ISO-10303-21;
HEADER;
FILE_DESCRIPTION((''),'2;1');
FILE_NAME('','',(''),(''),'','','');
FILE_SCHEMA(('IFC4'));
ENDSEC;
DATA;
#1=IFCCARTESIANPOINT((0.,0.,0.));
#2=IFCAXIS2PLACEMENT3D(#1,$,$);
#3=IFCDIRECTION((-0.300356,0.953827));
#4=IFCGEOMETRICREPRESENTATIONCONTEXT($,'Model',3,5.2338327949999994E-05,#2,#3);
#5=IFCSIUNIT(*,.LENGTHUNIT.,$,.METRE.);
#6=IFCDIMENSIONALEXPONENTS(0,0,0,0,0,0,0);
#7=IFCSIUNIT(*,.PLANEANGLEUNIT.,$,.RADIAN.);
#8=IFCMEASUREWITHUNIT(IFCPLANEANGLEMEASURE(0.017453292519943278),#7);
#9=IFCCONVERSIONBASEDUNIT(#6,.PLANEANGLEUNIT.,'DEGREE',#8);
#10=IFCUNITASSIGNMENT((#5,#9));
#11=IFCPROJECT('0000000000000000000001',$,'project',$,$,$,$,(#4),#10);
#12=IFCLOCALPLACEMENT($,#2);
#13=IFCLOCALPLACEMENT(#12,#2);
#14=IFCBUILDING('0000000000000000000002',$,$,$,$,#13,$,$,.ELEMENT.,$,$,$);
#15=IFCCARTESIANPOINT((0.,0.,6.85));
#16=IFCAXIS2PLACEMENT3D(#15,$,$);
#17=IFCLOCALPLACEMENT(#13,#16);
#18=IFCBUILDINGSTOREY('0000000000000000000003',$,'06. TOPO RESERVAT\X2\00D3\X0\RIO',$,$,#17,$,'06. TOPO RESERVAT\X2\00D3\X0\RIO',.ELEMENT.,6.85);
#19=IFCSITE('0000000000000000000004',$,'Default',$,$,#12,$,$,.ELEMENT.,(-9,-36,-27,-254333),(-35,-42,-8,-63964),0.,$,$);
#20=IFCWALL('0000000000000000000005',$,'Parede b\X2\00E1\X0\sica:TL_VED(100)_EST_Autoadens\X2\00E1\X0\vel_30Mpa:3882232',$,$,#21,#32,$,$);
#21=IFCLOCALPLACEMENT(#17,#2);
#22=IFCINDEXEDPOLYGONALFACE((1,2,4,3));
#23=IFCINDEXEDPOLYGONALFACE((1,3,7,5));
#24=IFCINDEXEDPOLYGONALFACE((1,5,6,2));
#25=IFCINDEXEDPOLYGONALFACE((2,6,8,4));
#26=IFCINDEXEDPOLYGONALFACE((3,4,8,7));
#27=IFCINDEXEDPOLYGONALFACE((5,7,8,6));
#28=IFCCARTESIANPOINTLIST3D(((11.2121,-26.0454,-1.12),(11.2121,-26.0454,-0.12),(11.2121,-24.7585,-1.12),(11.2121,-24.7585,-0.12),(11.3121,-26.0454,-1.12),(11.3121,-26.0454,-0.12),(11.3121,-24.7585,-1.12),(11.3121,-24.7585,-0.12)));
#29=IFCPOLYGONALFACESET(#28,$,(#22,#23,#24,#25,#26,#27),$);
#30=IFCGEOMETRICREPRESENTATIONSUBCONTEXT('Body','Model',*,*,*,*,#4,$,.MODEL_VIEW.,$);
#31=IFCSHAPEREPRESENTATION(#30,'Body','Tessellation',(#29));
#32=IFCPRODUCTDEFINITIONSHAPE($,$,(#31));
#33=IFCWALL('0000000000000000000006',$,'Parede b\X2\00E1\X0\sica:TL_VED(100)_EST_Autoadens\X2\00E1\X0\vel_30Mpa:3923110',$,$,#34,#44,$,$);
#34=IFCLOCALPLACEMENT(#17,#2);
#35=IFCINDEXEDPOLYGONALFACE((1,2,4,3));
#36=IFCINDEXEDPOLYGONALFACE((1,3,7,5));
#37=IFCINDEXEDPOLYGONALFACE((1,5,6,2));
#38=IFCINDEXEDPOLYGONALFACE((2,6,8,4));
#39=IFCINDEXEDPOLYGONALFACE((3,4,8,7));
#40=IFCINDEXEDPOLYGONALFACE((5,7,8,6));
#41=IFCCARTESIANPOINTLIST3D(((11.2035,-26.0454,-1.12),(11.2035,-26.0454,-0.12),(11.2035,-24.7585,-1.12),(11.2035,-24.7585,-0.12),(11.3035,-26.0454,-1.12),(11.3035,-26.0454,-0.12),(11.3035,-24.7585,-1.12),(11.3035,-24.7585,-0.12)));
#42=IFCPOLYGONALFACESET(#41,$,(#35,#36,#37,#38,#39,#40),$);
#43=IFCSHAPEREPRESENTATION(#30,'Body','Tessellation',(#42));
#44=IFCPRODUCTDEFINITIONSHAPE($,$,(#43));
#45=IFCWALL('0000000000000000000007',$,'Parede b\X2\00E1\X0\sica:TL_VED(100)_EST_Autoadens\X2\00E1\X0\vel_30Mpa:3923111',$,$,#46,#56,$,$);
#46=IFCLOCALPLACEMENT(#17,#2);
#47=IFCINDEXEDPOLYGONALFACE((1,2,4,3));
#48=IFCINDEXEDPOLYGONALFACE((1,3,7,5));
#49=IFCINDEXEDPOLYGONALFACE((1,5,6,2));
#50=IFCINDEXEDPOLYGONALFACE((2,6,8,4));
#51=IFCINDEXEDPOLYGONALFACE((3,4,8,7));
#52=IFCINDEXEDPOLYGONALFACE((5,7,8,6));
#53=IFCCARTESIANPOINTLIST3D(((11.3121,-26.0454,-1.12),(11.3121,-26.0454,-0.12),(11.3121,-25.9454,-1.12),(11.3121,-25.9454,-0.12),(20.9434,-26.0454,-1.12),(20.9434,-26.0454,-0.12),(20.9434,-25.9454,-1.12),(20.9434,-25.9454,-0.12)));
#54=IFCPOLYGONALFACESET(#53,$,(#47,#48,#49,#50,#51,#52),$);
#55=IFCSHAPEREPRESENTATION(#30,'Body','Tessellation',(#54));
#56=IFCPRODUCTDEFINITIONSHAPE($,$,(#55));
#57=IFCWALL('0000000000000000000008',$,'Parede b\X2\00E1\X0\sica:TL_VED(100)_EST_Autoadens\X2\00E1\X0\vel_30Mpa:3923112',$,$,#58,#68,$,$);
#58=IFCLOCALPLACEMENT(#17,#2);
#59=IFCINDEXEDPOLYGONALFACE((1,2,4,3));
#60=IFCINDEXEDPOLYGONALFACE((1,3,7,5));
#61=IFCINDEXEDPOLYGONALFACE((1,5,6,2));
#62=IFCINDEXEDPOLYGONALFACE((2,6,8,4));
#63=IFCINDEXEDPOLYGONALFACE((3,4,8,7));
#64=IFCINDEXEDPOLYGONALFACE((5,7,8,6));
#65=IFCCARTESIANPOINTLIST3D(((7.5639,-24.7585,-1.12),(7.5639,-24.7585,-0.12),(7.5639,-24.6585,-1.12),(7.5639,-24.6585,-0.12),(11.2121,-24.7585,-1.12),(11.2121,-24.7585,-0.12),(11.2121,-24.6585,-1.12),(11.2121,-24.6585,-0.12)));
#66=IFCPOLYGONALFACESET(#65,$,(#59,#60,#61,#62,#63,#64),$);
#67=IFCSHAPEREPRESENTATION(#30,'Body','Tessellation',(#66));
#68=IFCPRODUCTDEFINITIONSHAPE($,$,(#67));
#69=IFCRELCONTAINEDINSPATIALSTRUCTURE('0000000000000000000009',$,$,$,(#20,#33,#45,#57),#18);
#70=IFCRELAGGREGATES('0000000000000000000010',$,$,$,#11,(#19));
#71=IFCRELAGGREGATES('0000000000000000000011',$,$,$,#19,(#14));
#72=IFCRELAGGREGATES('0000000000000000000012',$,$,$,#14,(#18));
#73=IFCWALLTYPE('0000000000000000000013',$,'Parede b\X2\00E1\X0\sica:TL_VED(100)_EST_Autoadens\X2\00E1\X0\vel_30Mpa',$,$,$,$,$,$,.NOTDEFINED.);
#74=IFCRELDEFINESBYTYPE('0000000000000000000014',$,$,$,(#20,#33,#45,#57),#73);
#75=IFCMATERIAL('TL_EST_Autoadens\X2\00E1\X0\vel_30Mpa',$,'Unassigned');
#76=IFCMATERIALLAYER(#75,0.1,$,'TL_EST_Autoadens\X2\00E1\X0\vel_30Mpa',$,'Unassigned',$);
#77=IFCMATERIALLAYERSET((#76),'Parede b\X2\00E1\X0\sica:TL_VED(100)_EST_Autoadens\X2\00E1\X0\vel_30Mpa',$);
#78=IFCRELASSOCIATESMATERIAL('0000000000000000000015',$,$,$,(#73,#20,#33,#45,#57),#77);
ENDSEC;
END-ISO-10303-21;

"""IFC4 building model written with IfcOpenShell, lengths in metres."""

from ifc_helpers import new_model, entity, si_unit, converted_unit, direction, frame, frame_2d, origin, place, context, subcontext, project, spatial, rectangle, extrude, material, layer, layer_set, layer_usage, type_object, element, save


model = new_model("IFC4")

# Units and contexts
model_context = context("Model", 3, precision=5.2338327949999994e-05, world=origin(), true_north=direction((-0.300356, 0.953827)))
body_context = subcontext(model_context, "Body", "Model", "MODEL_VIEW")
ifc_project = project(units=[si_unit("LENGTHUNIT", "METRE"), converted_unit("PLANEANGLEUNIT", "DEGREE", entity("IfcPlaneAngleMeasure", 0.017453292519943278), si_unit("PLANEANGLEUNIT", "RADIAN"), dimensions=[0, 0, 0, 0, 0, 0, 0])], contexts=[model_context])

# Site, building, storey
site_placement = place(None, origin())
site = spatial("IfcSite", under=ifc_project, at=site_placement, Name="Default", CompositionType="ELEMENT", RefLatitude=(-9, -36, -27, -254333), RefLongitude=(-35, -42, -8, -63964), RefElevation=0.0)
building_placement = place(site_placement, origin())
building = spatial("IfcBuilding", under=site, at=building_placement, CompositionType="ELEMENT")
storey_placement = place(building_placement, frame((0.0, 0.0, 6.85)))
storey = spatial("IfcBuildingStorey", under=building, at=storey_placement, Name="06. TOPO RESERVATÓRIO", LongName="06. TOPO RESERVATÓRIO", CompositionType="ELEMENT", Elevation=6.85)

# Walls
ifc_material_1 = material(Name="TL_EST_Autoadensável_30Mpa", Category="Unassigned")
ifc_layer = layer(ifc_material_1, 0.1, Name="TL_EST_Autoadensável_30Mpa", Category="Unassigned")
ifc_layer_set = layer_set([ifc_layer], Name="Parede básica:TL_VED(100)_EST_Autoadensável_30Mpa")
ifc_layer_usage_1 = layer_usage(ifc_layer_set, "AXIS2", "NEGATIVE", 0.05)
wall_type = type_object("IfcWallType", Name="Parede básica:TL_VED(100)_EST_Autoadensável_30Mpa", PredefinedType="NOTDEFINED", material=ifc_layer_set)
wall_1_placement = place(storey_placement, frame((11.2621, -24.7585, -1.12), z_axis=(0.0, 0.0, 1.0), x_axis=(0.0, -1.0, 0.0)))
element("IfcWall", 1, at=wall_1_placement, inside=storey, type_object=wall_type, material=ifc_layer_usage_1, Name="Parede básica:TL_VED(100)_EST_Autoadensável_30Mpa:3882232", context=body_context, shape_type="SweptSolid", body=[
    extrude(rectangle(XDim=1.2869, YDim=0.1, at=frame_2d((0.6434, 0.0), x_axis=(-1.0, 0.0))), origin(), (0.0, 0.0, 1.0), 1.0),
])
ifc_layer_usage_2 = layer_usage(ifc_layer_set, "AXIS2", "NEGATIVE", 0.05)
wall_2_placement = place(storey_placement, frame((11.2535, -24.7585, -1.12), z_axis=(0.0, 0.0, 1.0), x_axis=(0.0, -1.0, 0.0)))
element("IfcWall", 2, at=wall_2_placement, inside=storey, type_object=wall_type, material=ifc_layer_usage_2, Name="Parede básica:TL_VED(100)_EST_Autoadensável_30Mpa:3923110", context=body_context, shape_type="SweptSolid", body=[
    extrude(rectangle(XDim=1.2869, YDim=0.1, at=frame_2d((0.6434, 0.0), x_axis=(-1.0, 0.0))), origin(), (0.0, 0.0, 1.0), 1.0),
])
ifc_layer_usage_3 = layer_usage(ifc_layer_set, "AXIS2", "NEGATIVE", 0.05)
wall_3_placement = place(storey_placement, frame((11.3121, -25.9954, -1.12)))
element("IfcWall", 3, at=wall_3_placement, inside=storey, type_object=wall_type, material=ifc_layer_usage_3, Name="Parede básica:TL_VED(100)_EST_Autoadensável_30Mpa:3923111", context=body_context, shape_type="SweptSolid", body=[
    extrude(rectangle(XDim=9.6313, YDim=0.1, at=frame_2d((4.8156, 0.0), x_axis=(-1.0, 0.0))), origin(), (0.0, 0.0, 1.0), 1.0),
])
ifc_layer_usage_4 = layer_usage(ifc_layer_set, "AXIS2", "NEGATIVE", 0.05)
wall_4_placement = place(storey_placement, frame((11.2121, -24.7085, -1.12), z_axis=(0.0, 0.0, 1.0), x_axis=(-1.0, 0.0, 0.0)))
element("IfcWall", 4, at=wall_4_placement, inside=storey, type_object=wall_type, material=ifc_layer_usage_4, Name="Parede básica:TL_VED(100)_EST_Autoadensável_30Mpa:3923112", context=body_context, shape_type="SweptSolid", body=[
    extrude(rectangle(XDim=3.6482, YDim=0.1, at=frame_2d((1.8241, 0.0), x_axis=(-1.0, 0.0))), origin(), (0.0, 0.0, 1.0), 1.0),
])

save(model, "model.ifc")
